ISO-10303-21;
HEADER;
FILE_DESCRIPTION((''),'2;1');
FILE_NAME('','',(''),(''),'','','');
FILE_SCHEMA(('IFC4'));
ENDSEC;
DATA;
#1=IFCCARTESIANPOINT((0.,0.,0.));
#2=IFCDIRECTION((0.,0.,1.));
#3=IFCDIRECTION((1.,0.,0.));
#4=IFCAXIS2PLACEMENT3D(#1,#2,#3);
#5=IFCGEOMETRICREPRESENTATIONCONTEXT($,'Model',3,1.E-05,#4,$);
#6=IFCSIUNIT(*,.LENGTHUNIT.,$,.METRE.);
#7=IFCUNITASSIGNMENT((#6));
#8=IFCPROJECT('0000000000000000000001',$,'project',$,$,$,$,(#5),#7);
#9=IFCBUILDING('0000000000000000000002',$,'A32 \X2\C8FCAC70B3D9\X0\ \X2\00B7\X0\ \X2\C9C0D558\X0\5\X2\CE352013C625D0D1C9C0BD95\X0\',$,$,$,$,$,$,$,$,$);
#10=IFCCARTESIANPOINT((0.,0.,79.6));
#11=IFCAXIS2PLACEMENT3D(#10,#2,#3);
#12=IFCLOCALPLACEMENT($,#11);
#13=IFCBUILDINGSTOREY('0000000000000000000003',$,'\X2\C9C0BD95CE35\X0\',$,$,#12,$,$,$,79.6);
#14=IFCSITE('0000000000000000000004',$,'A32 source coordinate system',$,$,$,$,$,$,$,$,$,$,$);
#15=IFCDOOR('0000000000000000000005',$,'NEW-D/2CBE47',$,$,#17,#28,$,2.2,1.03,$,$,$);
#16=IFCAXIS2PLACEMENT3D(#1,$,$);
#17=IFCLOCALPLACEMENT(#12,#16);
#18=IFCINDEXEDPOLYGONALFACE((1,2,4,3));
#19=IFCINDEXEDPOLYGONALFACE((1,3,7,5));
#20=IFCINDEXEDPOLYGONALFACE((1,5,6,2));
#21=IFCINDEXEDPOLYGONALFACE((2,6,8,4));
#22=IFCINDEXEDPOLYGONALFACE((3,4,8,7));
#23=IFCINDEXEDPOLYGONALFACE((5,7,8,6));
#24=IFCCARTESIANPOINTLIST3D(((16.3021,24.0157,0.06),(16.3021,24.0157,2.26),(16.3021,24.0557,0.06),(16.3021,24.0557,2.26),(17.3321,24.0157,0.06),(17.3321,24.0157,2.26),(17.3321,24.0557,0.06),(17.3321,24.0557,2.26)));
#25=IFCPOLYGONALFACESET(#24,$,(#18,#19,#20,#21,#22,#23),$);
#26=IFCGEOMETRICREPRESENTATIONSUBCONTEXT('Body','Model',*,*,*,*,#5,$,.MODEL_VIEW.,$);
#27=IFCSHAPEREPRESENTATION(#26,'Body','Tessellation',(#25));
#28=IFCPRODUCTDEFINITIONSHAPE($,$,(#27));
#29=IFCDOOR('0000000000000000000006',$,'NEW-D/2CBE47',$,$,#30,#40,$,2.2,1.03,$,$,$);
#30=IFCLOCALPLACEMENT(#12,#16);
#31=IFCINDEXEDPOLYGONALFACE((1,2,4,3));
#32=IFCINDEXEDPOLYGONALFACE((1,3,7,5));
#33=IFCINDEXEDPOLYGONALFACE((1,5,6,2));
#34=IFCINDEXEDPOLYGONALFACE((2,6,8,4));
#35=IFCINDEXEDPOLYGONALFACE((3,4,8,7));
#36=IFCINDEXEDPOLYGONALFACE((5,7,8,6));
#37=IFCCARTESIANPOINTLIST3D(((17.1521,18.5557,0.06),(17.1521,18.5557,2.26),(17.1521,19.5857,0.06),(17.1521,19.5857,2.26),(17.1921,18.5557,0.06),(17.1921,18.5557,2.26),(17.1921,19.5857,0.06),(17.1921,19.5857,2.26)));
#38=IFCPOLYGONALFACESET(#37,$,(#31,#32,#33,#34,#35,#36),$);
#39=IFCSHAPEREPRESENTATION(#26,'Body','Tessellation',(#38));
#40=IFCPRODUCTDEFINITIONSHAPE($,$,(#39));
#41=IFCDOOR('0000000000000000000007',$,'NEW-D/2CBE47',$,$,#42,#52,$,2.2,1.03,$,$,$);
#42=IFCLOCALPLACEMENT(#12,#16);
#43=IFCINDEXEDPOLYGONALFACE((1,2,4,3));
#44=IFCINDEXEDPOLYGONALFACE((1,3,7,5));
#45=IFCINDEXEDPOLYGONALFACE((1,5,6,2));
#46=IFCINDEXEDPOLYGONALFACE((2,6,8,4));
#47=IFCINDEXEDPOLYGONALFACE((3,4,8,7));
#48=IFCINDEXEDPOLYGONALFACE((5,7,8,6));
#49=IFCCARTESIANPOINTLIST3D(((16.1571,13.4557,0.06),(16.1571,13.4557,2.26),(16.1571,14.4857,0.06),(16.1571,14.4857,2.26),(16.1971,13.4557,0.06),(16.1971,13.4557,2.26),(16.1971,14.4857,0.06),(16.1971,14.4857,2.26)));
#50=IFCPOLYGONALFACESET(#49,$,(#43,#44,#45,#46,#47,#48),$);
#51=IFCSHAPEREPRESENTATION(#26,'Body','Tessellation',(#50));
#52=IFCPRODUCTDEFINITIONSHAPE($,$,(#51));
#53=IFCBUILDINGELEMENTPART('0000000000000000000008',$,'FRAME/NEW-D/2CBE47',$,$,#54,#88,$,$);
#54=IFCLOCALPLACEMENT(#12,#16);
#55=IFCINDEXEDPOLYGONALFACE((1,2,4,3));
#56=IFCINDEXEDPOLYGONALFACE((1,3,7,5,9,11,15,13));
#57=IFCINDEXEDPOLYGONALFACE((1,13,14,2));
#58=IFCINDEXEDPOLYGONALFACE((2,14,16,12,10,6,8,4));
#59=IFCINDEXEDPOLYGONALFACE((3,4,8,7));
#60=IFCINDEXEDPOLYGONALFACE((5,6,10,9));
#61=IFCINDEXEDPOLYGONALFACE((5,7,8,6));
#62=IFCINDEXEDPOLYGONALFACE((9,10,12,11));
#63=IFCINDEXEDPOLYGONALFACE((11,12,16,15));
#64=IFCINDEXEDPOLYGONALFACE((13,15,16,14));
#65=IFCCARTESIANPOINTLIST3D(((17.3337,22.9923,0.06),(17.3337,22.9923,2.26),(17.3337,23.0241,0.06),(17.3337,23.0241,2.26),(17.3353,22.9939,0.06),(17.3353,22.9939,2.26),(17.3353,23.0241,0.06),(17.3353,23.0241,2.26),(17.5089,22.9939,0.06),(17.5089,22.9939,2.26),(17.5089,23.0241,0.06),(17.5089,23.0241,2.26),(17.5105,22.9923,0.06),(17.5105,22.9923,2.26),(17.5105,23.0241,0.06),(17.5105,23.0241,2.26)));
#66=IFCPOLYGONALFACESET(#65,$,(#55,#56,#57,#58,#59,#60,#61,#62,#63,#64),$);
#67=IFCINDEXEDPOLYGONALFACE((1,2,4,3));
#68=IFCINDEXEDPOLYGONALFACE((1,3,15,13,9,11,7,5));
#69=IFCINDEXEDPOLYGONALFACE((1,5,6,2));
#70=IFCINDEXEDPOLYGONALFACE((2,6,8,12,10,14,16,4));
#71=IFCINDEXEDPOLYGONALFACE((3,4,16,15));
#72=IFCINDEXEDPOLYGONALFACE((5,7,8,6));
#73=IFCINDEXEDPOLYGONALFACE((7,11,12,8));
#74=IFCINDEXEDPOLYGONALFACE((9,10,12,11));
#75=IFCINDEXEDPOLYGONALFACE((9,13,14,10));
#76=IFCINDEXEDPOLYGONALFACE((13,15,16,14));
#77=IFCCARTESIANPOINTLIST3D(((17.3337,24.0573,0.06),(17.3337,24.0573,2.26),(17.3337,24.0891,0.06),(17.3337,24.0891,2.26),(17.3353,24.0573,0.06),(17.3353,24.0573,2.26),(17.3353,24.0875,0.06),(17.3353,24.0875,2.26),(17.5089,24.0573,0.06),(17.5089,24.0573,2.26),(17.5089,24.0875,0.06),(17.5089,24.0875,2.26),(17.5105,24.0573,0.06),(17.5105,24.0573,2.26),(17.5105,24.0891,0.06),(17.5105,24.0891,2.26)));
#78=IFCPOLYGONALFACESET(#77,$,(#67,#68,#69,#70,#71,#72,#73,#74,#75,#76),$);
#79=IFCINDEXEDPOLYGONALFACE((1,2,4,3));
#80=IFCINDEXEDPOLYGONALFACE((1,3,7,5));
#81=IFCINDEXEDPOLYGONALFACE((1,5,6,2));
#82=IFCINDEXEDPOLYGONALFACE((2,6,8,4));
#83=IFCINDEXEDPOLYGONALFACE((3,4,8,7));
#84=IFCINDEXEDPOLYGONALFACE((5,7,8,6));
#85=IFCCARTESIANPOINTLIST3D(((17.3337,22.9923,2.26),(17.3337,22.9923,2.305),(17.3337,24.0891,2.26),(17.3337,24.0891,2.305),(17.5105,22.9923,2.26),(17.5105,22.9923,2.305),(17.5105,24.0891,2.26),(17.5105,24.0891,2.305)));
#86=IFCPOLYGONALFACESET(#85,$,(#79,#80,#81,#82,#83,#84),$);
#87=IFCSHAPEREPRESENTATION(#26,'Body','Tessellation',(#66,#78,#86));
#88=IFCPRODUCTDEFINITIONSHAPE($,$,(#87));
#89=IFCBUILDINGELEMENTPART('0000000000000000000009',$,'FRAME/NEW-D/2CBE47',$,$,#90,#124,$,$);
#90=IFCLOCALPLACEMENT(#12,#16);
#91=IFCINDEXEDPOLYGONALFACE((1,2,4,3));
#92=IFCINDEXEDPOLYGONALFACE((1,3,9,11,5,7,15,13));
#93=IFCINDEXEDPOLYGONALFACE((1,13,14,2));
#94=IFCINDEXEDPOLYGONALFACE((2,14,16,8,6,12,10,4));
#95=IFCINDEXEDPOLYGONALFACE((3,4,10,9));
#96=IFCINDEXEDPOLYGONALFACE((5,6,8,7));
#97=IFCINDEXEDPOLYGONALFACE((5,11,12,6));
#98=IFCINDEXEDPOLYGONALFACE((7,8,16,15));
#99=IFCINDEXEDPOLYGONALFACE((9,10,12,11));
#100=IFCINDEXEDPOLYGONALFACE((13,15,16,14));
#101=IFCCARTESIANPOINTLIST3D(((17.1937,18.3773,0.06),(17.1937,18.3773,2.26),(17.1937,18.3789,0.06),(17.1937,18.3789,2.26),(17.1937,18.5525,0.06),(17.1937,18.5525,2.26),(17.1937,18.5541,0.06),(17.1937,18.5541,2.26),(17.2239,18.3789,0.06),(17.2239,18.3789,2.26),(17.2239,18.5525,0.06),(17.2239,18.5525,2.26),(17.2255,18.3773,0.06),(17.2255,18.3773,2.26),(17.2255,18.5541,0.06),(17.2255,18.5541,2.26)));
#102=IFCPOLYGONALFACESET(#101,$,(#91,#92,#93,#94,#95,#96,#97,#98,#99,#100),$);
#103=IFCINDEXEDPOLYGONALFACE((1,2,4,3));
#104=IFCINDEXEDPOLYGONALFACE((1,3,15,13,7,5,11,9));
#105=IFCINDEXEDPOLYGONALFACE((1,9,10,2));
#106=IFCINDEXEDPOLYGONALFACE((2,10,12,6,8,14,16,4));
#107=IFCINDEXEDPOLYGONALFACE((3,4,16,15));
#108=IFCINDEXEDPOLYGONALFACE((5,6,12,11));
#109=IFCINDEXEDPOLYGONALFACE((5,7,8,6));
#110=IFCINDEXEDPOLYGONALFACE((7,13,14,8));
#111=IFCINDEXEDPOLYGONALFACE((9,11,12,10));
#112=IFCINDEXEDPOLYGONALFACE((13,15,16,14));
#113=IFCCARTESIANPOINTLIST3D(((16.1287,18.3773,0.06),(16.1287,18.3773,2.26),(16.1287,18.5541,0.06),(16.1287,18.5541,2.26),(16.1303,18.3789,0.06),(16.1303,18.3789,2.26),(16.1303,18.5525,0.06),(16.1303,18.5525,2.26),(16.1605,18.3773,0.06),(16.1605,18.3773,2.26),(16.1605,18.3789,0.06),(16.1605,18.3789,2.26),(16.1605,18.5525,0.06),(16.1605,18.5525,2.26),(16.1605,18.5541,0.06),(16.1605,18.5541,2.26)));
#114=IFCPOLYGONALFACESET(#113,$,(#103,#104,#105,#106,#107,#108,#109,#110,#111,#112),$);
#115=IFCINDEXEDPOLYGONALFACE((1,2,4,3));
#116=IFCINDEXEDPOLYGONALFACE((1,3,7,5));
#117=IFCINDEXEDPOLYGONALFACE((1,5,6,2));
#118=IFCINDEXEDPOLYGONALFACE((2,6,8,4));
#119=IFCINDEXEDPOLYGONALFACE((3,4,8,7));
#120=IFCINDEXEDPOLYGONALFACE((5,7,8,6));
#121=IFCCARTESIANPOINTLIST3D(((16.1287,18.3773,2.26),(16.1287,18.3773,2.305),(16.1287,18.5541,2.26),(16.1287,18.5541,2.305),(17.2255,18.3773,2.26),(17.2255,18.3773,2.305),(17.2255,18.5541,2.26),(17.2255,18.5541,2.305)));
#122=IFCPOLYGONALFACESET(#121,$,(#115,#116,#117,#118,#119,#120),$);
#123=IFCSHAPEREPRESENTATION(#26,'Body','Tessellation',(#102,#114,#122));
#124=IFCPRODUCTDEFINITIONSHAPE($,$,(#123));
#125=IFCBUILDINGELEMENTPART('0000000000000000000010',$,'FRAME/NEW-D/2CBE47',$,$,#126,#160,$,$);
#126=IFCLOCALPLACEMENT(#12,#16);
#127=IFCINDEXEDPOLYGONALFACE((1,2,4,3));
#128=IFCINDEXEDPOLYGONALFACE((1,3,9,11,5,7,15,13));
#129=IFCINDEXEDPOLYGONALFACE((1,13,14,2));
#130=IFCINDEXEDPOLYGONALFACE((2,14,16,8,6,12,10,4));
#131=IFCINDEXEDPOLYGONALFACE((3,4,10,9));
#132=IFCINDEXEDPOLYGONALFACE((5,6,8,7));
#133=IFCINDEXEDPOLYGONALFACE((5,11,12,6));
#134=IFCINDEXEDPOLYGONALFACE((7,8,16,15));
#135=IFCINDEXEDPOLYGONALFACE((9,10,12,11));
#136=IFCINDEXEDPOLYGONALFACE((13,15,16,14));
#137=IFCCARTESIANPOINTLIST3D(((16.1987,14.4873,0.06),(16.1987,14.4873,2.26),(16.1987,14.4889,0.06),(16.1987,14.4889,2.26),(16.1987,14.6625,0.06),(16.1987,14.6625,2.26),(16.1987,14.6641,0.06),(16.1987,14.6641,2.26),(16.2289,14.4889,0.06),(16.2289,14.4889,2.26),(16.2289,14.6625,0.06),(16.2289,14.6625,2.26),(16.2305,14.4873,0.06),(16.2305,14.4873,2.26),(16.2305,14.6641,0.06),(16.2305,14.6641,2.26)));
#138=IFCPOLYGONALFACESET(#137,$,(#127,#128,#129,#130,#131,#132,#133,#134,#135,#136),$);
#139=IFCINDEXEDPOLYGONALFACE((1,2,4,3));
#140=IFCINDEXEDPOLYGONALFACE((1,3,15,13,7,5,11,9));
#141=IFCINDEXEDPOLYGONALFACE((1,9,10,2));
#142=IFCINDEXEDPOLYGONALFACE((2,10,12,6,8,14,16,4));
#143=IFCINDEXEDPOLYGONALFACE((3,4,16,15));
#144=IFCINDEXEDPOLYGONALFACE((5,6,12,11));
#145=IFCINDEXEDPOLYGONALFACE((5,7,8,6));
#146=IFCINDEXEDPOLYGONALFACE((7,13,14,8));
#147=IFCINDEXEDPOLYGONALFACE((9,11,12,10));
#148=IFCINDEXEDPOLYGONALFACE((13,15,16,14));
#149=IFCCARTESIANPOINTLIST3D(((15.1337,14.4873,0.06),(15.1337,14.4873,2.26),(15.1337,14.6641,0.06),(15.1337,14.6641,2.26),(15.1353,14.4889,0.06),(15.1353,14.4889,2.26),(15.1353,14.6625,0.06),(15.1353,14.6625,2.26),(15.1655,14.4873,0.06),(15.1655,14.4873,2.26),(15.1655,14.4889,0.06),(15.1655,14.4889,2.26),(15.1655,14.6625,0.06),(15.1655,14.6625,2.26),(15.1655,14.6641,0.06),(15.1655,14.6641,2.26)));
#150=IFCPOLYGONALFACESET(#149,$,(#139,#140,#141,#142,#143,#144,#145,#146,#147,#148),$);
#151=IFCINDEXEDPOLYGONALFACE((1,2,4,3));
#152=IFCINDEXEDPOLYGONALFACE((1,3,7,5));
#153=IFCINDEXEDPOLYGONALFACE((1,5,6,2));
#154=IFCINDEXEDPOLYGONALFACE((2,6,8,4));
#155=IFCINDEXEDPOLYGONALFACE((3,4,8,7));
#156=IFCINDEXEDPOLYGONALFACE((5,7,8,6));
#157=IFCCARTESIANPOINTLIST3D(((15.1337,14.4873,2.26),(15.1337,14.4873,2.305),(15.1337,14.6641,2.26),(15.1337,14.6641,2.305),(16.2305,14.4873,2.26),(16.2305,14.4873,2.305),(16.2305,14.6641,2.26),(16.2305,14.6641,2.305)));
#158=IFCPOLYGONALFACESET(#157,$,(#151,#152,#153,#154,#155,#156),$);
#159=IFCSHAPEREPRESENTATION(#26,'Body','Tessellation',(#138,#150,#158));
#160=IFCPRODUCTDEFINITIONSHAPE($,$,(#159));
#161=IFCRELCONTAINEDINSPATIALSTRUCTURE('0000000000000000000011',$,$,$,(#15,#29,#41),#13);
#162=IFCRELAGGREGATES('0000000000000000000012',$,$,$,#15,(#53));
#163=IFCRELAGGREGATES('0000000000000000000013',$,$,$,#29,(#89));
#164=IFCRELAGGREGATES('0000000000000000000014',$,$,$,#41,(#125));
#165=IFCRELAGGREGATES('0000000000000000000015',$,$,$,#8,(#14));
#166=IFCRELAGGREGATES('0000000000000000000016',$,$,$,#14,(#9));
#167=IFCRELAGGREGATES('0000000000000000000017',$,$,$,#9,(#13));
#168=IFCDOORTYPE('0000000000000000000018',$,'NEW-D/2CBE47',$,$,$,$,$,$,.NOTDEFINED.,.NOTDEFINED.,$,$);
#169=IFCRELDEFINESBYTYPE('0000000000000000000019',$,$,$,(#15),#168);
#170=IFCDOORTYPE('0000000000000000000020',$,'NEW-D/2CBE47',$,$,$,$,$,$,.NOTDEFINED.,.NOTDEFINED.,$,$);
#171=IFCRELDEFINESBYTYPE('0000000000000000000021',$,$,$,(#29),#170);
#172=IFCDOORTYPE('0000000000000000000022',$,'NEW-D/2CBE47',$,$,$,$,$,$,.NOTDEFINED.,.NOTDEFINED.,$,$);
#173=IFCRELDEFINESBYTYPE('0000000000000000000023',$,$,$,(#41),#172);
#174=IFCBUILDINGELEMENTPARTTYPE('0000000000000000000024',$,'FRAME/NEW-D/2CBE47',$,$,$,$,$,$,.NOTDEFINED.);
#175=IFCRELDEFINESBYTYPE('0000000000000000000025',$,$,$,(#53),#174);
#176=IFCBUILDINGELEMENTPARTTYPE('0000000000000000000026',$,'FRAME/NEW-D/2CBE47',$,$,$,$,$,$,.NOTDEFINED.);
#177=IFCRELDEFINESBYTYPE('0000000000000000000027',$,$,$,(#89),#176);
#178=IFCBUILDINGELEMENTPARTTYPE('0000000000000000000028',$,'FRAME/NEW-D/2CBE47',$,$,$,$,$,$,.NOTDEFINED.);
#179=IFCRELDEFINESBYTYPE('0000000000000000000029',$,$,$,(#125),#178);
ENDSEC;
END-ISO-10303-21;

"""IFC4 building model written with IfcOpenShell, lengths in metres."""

from ifc_helpers import new_model, si_unit, frame, origin, origin_with_axes, place, context, subcontext, project, spatial, polyline, outline, extrude, source, transform, mapped, type_object, type_shapes, element, aggregate, save


model = new_model("IFC4")

# Units and contexts
model_context = context("Model", 3, precision=1e-05, world=origin_with_axes())
body_context = subcontext(model_context, "Body", "Model", "MODEL_VIEW")
ifc_project = project(units=[si_unit("LENGTHUNIT", "METRE")], contexts=[model_context])

# Site, building, storey
site = spatial("IfcSite", under=ifc_project, Name="A32 source coordinate system")
building = spatial("IfcBuilding", under=site, Name="A32 주거동 · 지하5층–옥탑지붕")
storey_placement = place(None, frame((0.0, 0.0, 79.6), z_axis=(0.0, 0.0, 1.0), x_axis=(1.0, 0.0, 0.0)))
storey = spatial("IfcBuildingStorey", under=building, at=storey_placement, Name="지붕층", Elevation=79.6)

# Doors
door_type_1 = type_object("IfcDoorType", Name="NEW-D/2CBE47", OperationType="NOTDEFINED", PredefinedType="NOTDEFINED")
shared_shape_1 = source(origin(), body_context, "Body", "SweptSolid", [
    extrude(outline(polyline([(17.3321, 24.0557), (17.3321, 24.0157), (16.3021, 24.0157), (16.3021, 24.0557), (17.3321, 24.0557)])), frame((0.0, 0.0, 0.06)), (0.0, 0.0, 1.0), 2.2),
])
type_shapes(door_type_1, [shared_shape_1])
door_1_placement = place(storey_placement, origin_with_axes())
door_1 = element("IfcDoor", 1, at=door_1_placement, inside=storey, type_object=door_type_1, Name="NEW-D/2CBE47", OverallHeight=2.2, OverallWidth=1.03, context=body_context, shape_type="MappedRepresentation", body=[
    mapped(shared_shape_1, transform((0.0, 0.0, 0.0), scale=1.0)),
])
door_type_2 = type_object("IfcDoorType", Name="NEW-D/2CBE47", OperationType="NOTDEFINED", PredefinedType="NOTDEFINED")
shared_shape_2 = source(origin(), body_context, "Body", "SweptSolid", [
    extrude(outline(polyline([(17.1921, 18.5557), (17.1521, 18.5557), (17.1521, 19.5857), (17.1921, 19.5857), (17.1921, 18.5557)])), frame((0.0, 0.0, 0.06)), (0.0, 0.0, 1.0), 2.2),
])
type_shapes(door_type_2, [shared_shape_2])
door_2_placement = place(storey_placement, origin_with_axes())
door_2 = element("IfcDoor", 2, at=door_2_placement, inside=storey, type_object=door_type_2, Name="NEW-D/2CBE47", OverallHeight=2.2, OverallWidth=1.03, context=body_context, shape_type="MappedRepresentation", body=[
    mapped(shared_shape_2, transform((0.0, 0.0, 0.0), scale=1.0)),
])
door_type_3 = type_object("IfcDoorType", Name="NEW-D/2CBE47", OperationType="NOTDEFINED", PredefinedType="NOTDEFINED")
shared_shape_3 = source(origin(), body_context, "Body", "SweptSolid", [
    extrude(outline(polyline([(16.1571, 13.4557), (16.1571, 14.4857), (16.1971, 14.4857), (16.1971, 13.4557), (16.1571, 13.4557)])), frame((0.0, 0.0, 0.06)), (0.0, 0.0, 1.0), 2.2),
])
type_shapes(door_type_3, [shared_shape_3])
door_3_placement = place(storey_placement, origin_with_axes())
door_3 = element("IfcDoor", 3, at=door_3_placement, inside=storey, type_object=door_type_3, Name="NEW-D/2CBE47", OverallHeight=2.2, OverallWidth=1.03, context=body_context, shape_type="MappedRepresentation", body=[
    mapped(shared_shape_3, transform((0.0, 0.0, 0.0), scale=1.0)),
])

# Building element parts
building_element_part_type_1 = type_object("IfcBuildingElementPartType", Name="FRAME/NEW-D/2CBE47", PredefinedType="NOTDEFINED")
shared_shape_4 = source(origin(), body_context, "Body", "SweptSolid", [
    extrude(outline(polyline([(17.3353, 22.9939), (17.5089, 22.9939), (17.5089, 23.0241), (17.5105, 23.0241), (17.5105, 22.9923), (17.3337, 22.9923), (17.3337, 23.0241), (17.3353, 23.0241), (17.3353, 22.9939)])), frame((0.0, 0.0, 0.06)), (0.0, 0.0, 1.0), 2.2),
    extrude(outline(polyline([(17.5105, 24.0891), (17.5105, 24.0573), (17.5089, 24.0573), (17.5089, 24.0875), (17.3353, 24.0875), (17.3353, 24.0573), (17.3337, 24.0573), (17.3337, 24.0891), (17.5105, 24.0891)])), frame((0.0, 0.0, 0.06)), (0.0, 0.0, 1.0), 2.2),
    extrude(outline(polyline([(17.5105, 22.9923), (17.5105, 24.0891), (17.3337, 24.0891), (17.3337, 22.9923), (17.5105, 22.9923)])), frame((0.0, 0.0, 2.26)), (0.0, 0.0, 1.0), 0.045),
])
type_shapes(building_element_part_type_1, [shared_shape_4])
building_element_part_1_placement = place(door_1_placement, origin_with_axes())
building_element_part_1 = element("IfcBuildingElementPart", 4, at=building_element_part_1_placement, type_object=building_element_part_type_1, Name="FRAME/NEW-D/2CBE47", context=body_context, shape_type="MappedRepresentation", body=[
    mapped(shared_shape_4, transform((0.0, 0.0, 0.0), scale=1.0)),
])
aggregate(door_1, [building_element_part_1])
building_element_part_type_2 = type_object("IfcBuildingElementPartType", Name="FRAME/NEW-D/2CBE47", PredefinedType="NOTDEFINED")
shared_shape_5 = source(origin(), body_context, "Body", "SweptSolid", [
    extrude(outline(polyline([(17.2255, 18.3773), (17.1937, 18.3773), (17.1937, 18.3789), (17.2239, 18.3789), (17.2239, 18.5525), (17.1937, 18.5525), (17.1937, 18.5541), (17.2255, 18.5541), (17.2255, 18.3773)])), frame((0.0, 0.0, 0.06)), (0.0, 0.0, 1.0), 2.2),
    extrude(outline(polyline([(16.1303, 18.5525), (16.1303, 18.3789), (16.1605, 18.3789), (16.1605, 18.3773), (16.1287, 18.3773), (16.1287, 18.5541), (16.1605, 18.5541), (16.1605, 18.5525), (16.1303, 18.5525)])), frame((0.0, 0.0, 0.06)), (0.0, 0.0, 1.0), 2.2),
    extrude(outline(polyline([(17.2255, 18.3773), (17.2255, 18.5541), (16.1287, 18.5541), (16.1287, 18.3773), (17.2255, 18.3773)])), frame((0.0, 0.0, 2.26)), (0.0, 0.0, 1.0), 0.045),
])
type_shapes(building_element_part_type_2, [shared_shape_5])
building_element_part_2_placement = place(door_2_placement, origin_with_axes())
building_element_part_2 = element("IfcBuildingElementPart", 5, at=building_element_part_2_placement, type_object=building_element_part_type_2, Name="FRAME/NEW-D/2CBE47", context=body_context, shape_type="MappedRepresentation", body=[
    mapped(shared_shape_5, transform((0.0, 0.0, 0.0), scale=1.0)),
])
aggregate(door_2, [building_element_part_2])
building_element_part_type_3 = type_object("IfcBuildingElementPartType", Name="FRAME/NEW-D/2CBE47", PredefinedType="NOTDEFINED")
shared_shape_6 = source(origin(), body_context, "Body", "SweptSolid", [
    extrude(outline(polyline([(16.2289, 14.4889), (16.2289, 14.6625), (16.1987, 14.6625), (16.1987, 14.6641), (16.2305, 14.6641), (16.2305, 14.4873), (16.1987, 14.4873), (16.1987, 14.4889), (16.2289, 14.4889)])), frame((0.0, 0.0, 0.06)), (0.0, 0.0, 1.0), 2.2),
    extrude(outline(polyline([(15.1337, 14.6641), (15.1655, 14.6641), (15.1655, 14.6625), (15.1353, 14.6625), (15.1353, 14.4889), (15.1655, 14.4889), (15.1655, 14.4873), (15.1337, 14.4873), (15.1337, 14.6641)])), frame((0.0, 0.0, 0.06)), (0.0, 0.0, 1.0), 2.2),
    extrude(outline(polyline([(16.2305, 14.4873), (16.2305, 14.6641), (15.1337, 14.6641), (15.1337, 14.4873), (16.2305, 14.4873)])), frame((0.0, 0.0, 2.26)), (0.0, 0.0, 1.0), 0.045),
])
type_shapes(building_element_part_type_3, [shared_shape_6])
building_element_part_3_placement = place(door_3_placement, origin_with_axes())
building_element_part_3 = element("IfcBuildingElementPart", 6, at=building_element_part_3_placement, type_object=building_element_part_type_3, Name="FRAME/NEW-D/2CBE47", context=body_context, shape_type="MappedRepresentation", body=[
    mapped(shared_shape_6, transform((0.0, 0.0, 0.0), scale=1.0)),
])
aggregate(door_3, [building_element_part_3])

save(model, "model.ifc")
